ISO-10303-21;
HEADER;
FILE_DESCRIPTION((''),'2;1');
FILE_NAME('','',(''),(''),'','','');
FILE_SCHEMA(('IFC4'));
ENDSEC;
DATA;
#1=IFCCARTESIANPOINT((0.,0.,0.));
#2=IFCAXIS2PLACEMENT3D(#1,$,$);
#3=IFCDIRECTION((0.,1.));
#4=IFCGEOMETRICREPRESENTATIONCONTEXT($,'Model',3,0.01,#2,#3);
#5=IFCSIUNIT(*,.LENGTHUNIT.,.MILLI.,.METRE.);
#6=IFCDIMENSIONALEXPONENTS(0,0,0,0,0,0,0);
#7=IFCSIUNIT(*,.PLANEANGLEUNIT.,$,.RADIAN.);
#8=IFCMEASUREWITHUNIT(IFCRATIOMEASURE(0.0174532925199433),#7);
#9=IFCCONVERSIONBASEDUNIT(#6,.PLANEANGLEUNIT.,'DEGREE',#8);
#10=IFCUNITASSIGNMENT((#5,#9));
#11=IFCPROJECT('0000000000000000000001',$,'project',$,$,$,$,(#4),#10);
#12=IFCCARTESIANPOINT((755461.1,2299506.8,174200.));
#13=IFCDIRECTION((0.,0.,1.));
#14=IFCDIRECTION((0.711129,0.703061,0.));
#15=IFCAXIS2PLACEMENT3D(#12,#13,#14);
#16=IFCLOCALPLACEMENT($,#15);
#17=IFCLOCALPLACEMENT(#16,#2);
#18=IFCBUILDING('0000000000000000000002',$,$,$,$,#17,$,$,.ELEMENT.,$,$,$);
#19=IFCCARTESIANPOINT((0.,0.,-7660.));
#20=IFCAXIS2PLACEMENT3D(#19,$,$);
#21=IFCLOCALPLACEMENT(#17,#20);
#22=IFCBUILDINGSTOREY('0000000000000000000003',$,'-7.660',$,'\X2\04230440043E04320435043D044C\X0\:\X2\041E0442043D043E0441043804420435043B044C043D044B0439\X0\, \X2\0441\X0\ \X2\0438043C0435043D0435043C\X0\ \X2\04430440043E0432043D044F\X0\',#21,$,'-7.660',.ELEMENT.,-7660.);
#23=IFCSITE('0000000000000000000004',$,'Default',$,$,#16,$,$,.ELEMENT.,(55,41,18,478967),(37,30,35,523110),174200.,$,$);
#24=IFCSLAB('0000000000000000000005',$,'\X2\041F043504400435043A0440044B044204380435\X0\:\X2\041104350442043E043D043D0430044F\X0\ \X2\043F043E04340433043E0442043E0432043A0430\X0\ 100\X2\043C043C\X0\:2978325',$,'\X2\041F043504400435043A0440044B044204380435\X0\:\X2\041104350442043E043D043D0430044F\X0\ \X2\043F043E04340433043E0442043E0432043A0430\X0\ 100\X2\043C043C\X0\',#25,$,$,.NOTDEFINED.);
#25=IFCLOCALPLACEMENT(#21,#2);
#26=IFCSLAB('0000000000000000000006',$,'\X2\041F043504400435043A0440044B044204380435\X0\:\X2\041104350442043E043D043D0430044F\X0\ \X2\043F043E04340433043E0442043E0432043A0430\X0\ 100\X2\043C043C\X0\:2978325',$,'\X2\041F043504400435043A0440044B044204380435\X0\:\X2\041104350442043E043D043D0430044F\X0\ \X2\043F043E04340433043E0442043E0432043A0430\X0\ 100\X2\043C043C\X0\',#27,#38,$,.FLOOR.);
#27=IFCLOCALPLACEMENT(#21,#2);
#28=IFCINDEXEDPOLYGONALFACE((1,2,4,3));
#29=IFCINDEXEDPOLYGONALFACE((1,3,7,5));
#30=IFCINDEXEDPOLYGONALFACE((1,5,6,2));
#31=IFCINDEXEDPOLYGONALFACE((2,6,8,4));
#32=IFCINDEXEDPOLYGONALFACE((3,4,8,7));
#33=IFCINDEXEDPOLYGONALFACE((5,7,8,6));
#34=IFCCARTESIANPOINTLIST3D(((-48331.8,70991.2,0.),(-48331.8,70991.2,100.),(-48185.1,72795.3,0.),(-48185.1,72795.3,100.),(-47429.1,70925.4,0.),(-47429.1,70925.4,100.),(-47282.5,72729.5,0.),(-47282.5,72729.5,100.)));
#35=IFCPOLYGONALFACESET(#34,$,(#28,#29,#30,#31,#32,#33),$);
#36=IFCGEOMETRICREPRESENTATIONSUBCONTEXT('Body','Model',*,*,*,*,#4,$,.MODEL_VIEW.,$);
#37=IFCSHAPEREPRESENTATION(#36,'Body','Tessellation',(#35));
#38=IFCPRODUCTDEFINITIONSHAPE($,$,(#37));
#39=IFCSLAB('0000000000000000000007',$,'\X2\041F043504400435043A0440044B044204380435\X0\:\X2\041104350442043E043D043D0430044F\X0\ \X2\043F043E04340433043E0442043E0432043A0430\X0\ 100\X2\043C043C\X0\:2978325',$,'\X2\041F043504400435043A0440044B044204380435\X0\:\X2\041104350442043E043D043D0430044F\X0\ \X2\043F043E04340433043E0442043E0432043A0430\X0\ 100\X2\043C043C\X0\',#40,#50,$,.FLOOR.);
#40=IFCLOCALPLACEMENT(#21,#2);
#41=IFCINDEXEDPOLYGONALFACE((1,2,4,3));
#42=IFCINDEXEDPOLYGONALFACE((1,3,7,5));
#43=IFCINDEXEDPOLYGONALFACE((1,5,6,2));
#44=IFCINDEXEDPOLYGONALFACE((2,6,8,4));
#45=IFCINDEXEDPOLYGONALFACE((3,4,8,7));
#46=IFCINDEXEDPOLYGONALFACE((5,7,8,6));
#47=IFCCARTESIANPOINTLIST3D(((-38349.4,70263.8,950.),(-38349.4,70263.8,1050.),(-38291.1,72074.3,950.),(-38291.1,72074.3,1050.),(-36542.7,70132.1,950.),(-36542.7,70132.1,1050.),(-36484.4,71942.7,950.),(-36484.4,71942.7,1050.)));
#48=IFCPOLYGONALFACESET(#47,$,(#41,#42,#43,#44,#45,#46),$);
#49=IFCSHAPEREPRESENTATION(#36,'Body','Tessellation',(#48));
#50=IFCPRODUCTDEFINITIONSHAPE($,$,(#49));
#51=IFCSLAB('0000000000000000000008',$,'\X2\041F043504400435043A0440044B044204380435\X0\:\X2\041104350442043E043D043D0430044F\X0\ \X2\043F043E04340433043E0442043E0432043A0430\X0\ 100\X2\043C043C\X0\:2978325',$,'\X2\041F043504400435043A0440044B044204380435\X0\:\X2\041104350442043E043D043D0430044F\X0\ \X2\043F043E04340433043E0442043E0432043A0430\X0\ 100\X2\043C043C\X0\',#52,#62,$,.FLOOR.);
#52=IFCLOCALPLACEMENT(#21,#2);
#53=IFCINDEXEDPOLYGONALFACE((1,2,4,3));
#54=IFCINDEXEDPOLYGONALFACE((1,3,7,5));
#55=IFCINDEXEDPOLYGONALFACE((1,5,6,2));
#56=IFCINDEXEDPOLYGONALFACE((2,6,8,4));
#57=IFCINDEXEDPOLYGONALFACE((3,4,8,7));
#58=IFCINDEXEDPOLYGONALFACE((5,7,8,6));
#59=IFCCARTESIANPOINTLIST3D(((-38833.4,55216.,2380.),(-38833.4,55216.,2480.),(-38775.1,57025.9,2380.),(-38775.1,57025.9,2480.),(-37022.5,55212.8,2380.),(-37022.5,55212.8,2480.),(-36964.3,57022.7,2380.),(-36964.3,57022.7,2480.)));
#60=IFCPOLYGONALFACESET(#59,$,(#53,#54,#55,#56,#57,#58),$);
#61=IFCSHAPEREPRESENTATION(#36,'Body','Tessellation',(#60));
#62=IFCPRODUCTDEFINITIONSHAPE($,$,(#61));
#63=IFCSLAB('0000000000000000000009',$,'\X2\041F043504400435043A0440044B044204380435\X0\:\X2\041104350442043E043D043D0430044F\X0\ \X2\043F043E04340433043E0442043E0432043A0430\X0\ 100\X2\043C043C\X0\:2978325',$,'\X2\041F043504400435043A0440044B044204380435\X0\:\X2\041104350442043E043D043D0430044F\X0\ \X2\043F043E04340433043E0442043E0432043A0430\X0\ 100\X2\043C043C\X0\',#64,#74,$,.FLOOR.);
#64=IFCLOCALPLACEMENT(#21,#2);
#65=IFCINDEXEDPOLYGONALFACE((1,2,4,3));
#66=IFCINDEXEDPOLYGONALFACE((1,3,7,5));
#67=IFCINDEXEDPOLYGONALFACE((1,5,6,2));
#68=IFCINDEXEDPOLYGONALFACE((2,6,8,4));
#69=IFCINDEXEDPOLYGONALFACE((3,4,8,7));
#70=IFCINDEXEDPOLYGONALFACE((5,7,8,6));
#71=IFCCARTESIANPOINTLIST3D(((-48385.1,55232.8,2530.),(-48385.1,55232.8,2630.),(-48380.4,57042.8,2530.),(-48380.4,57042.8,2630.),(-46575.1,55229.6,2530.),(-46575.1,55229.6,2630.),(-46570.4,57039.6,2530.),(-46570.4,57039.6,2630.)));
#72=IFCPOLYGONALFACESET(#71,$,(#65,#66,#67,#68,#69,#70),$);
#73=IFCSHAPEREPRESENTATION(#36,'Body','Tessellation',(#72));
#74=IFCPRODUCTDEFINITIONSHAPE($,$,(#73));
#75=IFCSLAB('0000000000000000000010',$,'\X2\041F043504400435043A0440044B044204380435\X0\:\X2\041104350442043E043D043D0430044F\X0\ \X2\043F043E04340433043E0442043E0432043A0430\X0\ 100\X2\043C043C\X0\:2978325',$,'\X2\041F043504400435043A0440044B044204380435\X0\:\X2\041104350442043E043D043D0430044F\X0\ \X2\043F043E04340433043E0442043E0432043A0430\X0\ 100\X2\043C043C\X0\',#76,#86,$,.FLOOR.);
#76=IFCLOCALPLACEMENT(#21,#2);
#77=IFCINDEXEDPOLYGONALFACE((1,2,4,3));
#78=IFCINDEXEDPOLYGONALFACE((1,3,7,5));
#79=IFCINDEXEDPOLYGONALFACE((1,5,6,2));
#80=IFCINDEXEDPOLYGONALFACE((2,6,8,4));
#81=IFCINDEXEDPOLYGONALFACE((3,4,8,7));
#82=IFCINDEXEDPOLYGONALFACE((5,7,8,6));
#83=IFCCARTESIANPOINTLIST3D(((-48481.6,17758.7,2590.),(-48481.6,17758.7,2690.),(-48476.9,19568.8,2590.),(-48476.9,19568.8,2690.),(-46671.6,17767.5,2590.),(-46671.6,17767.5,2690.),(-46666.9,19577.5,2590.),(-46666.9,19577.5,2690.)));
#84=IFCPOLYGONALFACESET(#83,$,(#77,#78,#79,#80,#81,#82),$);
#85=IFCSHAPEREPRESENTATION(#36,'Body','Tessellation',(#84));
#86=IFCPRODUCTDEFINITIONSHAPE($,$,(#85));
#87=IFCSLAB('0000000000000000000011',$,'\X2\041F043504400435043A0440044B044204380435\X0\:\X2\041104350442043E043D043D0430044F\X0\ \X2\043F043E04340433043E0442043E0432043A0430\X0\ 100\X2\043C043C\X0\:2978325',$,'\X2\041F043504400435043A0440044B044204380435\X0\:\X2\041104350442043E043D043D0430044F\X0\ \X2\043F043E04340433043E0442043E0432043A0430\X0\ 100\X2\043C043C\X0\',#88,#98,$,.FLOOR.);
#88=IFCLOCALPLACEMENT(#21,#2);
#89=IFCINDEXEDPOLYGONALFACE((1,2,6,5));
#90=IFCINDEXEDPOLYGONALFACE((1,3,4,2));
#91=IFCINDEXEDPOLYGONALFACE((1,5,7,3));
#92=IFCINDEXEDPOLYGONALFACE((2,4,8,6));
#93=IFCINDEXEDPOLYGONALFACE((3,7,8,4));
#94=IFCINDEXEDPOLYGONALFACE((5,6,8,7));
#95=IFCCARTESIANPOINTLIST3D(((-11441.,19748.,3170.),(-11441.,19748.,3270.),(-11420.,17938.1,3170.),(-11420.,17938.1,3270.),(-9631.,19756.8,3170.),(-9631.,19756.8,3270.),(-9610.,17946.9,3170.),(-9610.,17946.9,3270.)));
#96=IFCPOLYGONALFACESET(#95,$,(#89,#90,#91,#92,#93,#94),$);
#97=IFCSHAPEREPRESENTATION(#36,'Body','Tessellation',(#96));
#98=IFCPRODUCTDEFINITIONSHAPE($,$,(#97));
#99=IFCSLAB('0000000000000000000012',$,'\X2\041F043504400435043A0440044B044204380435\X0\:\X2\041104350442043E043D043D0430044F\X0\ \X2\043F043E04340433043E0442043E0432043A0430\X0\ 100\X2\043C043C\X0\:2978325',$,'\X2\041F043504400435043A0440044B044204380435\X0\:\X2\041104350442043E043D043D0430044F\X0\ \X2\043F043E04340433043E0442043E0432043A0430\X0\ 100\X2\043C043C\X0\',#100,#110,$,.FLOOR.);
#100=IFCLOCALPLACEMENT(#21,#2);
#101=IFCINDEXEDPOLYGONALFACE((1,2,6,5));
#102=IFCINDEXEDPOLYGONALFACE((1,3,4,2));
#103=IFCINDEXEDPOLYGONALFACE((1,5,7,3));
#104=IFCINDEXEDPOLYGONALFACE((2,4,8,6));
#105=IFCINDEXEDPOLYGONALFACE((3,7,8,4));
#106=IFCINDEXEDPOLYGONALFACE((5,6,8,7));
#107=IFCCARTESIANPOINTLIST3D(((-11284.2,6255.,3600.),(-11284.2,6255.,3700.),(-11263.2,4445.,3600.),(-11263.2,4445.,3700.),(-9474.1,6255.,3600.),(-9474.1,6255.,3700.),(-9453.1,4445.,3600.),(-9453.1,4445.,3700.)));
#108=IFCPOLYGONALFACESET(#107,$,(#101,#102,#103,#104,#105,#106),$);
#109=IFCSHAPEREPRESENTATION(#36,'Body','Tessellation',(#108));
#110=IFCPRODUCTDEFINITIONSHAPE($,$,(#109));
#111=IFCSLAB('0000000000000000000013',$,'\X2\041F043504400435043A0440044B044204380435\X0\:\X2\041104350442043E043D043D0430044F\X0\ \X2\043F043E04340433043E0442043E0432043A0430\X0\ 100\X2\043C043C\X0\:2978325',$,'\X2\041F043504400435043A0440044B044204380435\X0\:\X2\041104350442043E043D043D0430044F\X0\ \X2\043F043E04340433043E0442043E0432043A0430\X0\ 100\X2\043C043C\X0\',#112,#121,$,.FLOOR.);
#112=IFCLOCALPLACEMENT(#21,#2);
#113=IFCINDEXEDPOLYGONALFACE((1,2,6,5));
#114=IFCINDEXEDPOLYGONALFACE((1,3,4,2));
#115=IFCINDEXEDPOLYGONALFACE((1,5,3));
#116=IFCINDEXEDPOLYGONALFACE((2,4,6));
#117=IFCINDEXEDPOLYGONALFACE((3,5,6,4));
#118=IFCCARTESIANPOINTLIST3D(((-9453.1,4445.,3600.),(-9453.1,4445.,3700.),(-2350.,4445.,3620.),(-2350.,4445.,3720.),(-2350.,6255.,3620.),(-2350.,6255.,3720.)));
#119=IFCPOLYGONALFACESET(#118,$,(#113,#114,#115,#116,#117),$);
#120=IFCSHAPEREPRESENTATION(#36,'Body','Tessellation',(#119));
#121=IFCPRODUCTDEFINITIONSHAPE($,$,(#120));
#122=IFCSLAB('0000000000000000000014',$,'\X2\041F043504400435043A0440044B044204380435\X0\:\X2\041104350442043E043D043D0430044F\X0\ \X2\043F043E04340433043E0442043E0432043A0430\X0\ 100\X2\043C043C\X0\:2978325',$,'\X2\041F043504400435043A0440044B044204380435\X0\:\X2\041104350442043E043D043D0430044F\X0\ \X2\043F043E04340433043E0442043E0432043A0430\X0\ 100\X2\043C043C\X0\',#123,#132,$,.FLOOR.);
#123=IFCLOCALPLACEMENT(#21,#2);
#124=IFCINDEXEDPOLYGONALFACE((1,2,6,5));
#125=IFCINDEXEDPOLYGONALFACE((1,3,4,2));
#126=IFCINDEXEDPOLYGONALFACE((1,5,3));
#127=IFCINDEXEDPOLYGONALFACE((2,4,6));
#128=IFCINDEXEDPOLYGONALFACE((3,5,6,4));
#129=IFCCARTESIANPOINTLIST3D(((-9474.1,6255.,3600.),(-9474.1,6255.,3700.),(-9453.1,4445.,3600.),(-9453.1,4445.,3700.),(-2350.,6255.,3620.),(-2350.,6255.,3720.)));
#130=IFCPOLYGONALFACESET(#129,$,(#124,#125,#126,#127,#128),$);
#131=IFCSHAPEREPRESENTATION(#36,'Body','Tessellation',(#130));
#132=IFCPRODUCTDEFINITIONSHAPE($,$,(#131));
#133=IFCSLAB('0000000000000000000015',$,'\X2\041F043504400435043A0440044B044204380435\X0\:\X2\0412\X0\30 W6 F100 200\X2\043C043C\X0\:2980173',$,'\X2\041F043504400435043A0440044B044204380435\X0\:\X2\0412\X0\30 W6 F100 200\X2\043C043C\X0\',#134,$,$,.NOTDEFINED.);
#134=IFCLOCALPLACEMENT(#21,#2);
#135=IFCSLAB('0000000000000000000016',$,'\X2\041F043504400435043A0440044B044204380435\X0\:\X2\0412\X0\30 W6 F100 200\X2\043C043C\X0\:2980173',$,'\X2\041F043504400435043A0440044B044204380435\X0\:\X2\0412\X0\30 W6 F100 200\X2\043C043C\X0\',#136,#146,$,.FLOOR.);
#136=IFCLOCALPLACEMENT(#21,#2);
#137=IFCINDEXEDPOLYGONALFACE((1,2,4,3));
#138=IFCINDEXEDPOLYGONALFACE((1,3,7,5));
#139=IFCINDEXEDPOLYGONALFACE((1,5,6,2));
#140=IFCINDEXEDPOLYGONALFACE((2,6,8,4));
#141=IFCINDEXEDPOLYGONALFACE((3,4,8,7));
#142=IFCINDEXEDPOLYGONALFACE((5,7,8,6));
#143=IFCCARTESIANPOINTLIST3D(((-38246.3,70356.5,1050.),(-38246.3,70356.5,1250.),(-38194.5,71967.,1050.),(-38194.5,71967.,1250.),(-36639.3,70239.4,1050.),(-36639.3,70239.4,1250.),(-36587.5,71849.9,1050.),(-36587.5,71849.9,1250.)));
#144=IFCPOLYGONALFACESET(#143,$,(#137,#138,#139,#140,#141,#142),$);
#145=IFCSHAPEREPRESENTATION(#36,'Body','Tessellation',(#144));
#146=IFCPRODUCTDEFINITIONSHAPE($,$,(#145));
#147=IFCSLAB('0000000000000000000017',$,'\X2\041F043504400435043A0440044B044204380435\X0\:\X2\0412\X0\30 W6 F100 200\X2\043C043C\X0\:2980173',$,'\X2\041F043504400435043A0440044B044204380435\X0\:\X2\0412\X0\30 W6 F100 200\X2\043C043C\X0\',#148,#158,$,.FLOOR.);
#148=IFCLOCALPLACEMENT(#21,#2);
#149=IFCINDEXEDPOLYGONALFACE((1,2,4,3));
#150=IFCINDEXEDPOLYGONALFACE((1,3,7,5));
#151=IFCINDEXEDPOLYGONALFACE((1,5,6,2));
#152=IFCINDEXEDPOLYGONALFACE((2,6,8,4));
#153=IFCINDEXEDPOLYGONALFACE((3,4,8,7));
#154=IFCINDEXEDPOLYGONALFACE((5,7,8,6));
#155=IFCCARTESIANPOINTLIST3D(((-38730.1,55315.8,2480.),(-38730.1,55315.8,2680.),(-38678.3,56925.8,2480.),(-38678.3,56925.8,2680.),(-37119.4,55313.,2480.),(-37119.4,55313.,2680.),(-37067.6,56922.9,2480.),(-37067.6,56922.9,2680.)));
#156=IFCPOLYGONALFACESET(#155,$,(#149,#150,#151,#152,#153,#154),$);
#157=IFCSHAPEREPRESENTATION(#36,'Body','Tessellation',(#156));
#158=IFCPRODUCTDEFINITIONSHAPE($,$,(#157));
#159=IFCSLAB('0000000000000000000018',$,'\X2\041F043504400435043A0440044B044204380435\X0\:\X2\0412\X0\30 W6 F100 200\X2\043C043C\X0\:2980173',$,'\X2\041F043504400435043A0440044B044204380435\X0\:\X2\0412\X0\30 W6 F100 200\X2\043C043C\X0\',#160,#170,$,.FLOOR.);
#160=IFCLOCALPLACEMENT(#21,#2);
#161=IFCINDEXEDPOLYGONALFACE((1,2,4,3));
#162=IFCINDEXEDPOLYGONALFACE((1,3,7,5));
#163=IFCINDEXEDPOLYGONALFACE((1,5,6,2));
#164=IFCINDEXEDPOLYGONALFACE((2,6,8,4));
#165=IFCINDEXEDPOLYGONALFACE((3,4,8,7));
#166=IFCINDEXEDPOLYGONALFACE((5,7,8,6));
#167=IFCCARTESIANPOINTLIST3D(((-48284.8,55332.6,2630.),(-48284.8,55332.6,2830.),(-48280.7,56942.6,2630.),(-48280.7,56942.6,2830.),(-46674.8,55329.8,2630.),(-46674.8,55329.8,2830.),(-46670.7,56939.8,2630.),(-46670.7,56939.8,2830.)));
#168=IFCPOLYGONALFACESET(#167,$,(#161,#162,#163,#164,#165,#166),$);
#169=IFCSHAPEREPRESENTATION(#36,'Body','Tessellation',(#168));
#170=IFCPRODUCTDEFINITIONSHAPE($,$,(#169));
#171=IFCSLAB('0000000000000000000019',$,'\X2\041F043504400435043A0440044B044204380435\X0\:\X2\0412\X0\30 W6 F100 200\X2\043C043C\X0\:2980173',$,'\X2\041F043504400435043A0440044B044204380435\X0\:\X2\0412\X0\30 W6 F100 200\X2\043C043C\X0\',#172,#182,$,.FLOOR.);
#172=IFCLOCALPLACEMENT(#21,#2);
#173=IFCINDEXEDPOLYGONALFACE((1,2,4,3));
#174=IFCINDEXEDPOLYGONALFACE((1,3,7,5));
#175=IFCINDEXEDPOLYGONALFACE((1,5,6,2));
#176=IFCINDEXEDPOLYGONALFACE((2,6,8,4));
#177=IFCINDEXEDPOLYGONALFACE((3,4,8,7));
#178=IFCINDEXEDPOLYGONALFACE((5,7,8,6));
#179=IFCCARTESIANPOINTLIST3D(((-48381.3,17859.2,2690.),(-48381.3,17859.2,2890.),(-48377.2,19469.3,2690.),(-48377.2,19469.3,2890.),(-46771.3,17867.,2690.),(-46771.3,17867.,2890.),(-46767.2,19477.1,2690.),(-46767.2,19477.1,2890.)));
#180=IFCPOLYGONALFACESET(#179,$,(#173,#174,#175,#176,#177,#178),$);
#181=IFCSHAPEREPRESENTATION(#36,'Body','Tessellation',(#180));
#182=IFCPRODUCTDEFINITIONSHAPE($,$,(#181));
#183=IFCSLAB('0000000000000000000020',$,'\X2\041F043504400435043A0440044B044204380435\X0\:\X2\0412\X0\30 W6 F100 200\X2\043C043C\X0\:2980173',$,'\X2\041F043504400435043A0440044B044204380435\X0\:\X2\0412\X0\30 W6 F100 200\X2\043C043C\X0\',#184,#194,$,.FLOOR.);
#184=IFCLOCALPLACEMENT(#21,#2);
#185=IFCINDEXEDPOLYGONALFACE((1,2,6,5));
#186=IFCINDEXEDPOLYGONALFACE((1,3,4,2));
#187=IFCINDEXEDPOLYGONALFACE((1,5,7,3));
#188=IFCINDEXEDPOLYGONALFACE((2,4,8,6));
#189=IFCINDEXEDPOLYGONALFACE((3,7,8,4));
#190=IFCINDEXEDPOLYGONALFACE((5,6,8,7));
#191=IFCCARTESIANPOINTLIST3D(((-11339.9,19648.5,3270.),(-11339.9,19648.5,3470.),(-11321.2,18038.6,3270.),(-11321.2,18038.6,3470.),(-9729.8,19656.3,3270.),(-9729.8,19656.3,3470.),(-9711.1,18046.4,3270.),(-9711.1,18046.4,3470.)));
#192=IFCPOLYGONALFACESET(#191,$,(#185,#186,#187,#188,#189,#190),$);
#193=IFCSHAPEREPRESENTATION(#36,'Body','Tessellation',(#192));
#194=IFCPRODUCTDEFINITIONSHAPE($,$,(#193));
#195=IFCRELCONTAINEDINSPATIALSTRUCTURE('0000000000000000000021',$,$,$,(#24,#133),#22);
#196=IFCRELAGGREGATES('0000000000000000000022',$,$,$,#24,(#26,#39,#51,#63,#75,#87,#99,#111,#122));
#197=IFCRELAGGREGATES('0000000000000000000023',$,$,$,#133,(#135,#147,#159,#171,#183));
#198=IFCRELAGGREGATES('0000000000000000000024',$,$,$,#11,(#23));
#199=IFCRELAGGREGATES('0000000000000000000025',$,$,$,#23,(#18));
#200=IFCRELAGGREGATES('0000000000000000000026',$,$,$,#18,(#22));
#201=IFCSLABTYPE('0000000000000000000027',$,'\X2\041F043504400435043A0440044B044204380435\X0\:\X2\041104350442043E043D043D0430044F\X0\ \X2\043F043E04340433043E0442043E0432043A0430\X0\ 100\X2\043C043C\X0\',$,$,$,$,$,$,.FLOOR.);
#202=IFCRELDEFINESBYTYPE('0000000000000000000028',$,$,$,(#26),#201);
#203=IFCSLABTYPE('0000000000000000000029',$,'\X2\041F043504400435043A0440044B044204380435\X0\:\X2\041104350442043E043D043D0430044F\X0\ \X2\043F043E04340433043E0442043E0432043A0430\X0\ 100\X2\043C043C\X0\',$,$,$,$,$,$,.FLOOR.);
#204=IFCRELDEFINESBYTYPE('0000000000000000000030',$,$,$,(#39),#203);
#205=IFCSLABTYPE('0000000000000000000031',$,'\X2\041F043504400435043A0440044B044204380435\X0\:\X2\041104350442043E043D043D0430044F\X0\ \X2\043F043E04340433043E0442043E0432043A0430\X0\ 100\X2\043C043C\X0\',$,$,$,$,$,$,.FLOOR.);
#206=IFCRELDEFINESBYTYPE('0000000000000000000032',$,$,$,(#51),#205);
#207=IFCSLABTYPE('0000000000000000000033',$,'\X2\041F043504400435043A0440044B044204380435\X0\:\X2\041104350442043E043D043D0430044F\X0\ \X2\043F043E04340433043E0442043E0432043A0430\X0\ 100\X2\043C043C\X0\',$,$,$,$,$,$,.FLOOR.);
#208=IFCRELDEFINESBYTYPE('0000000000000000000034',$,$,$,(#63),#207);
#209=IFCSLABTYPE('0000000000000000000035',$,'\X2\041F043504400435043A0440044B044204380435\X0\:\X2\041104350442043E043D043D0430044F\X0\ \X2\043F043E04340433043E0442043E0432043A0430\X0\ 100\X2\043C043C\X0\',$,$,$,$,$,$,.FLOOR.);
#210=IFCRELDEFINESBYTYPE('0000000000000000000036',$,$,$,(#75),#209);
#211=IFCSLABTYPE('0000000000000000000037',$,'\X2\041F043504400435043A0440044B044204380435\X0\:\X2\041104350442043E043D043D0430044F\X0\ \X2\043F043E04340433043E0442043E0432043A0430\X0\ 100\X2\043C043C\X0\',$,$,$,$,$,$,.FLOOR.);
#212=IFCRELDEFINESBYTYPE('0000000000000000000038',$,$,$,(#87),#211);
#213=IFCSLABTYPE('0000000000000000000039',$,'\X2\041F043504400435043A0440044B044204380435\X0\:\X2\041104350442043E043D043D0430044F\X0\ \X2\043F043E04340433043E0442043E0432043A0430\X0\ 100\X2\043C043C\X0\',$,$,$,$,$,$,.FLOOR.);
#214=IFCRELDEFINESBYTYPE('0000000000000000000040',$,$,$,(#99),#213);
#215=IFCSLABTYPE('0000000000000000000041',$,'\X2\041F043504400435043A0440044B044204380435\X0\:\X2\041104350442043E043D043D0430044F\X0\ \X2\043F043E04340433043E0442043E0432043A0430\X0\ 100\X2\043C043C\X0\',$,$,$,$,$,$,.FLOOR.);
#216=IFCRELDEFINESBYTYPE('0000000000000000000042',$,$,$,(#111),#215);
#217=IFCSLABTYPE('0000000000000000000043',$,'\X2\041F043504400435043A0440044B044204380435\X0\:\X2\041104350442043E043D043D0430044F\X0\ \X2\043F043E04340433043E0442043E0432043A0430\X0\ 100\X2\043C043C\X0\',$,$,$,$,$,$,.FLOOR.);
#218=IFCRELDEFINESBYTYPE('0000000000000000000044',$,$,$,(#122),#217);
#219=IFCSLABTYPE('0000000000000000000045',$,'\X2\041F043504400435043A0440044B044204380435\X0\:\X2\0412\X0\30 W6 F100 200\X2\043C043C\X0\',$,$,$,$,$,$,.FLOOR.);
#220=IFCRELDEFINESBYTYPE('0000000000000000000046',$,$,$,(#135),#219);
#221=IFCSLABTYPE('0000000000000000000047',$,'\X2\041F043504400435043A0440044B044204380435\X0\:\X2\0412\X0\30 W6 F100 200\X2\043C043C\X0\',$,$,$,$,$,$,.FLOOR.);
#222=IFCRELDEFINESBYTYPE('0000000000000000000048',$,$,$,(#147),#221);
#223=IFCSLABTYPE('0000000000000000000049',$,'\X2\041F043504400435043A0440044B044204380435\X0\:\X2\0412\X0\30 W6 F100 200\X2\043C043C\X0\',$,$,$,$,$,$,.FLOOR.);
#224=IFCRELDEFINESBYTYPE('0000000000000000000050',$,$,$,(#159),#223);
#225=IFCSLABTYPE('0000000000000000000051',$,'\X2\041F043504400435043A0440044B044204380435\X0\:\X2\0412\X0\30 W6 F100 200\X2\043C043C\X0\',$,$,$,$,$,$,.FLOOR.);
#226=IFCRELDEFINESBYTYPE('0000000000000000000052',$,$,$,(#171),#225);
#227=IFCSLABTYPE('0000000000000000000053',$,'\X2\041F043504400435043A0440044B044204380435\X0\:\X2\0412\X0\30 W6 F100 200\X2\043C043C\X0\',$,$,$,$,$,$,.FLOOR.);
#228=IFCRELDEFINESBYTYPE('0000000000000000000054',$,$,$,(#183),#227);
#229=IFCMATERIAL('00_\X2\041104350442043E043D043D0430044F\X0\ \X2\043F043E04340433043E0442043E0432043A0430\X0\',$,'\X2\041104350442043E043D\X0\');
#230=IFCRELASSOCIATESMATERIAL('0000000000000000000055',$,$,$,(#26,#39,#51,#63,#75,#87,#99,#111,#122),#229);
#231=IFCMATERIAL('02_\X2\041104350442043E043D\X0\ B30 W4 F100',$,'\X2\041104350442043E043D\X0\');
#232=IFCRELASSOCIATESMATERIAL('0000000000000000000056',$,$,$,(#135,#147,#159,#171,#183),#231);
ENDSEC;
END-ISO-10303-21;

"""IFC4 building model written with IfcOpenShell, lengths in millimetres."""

from ifc_helpers import new_model, entity, si_unit, converted_unit, direction, frame, origin, place, context, subcontext, project, spatial, indexed_curve, outline, extrude, material, type_object, element, aggregate, save


model = new_model("IFC4")

# Units and contexts
model_context = context("Model", 3, precision=0.01, world=origin(), true_north=direction((0.0, 1.0)))
body_context = subcontext(model_context, "Body", "Model", "MODEL_VIEW")
ifc_project = project(units=[si_unit("LENGTHUNIT", "METRE", prefix="MILLI"), converted_unit("PLANEANGLEUNIT", "DEGREE", entity("IfcRatioMeasure", 0.0174532925199433), si_unit("PLANEANGLEUNIT", "RADIAN"), dimensions=[0, 0, 0, 0, 0, 0, 0])], contexts=[model_context])

# Site, building, storey
site_placement = place(None, frame((755461.1, 2299506.8, 174200.0), z_axis=(0.0, 0.0, 1.0), x_axis=(0.711129, 0.703061, 0.0)))
site = spatial("IfcSite", under=ifc_project, at=site_placement, Name="Default", CompositionType="ELEMENT", RefLatitude=(55, 41, 18, 478967), RefLongitude=(37, 30, 35, 523110), RefElevation=174200.0)
building_placement = place(site_placement, origin())
building = spatial("IfcBuilding", under=site, at=building_placement, CompositionType="ELEMENT")
storey_placement = place(building_placement, frame((0.0, 0.0, -7660.0)))
storey = spatial("IfcBuildingStorey", under=building, at=storey_placement, Name="-7.660", ObjectType="Уровень:Относительный, с именем уровня", LongName="-7.660", CompositionType="ELEMENT", Elevation=-7660.0)

# Slabs
slab_1_placement = place(storey_placement, frame((-48481.6, 4445.0, 0.0)))
slab_1 = element("IfcSlab", 1, at=slab_1_placement, inside=storey, Name="Перекрытие:Бетонная подготовка 100мм:2978325", ObjectType="Перекрытие:Бетонная подготовка 100мм", PredefinedType="NOTDEFINED")
ifc_material_1 = material(Name="00_Бетонная подготовка", Category="Бетон")
slab_type_1 = type_object("IfcSlabType", Name="Перекрытие:Бетонная подготовка 100мм", PredefinedType="FLOOR")
slab_2_placement = place(slab_1_placement, origin())
slab_2 = element("IfcSlab", 2, at=slab_2_placement, type_object=slab_type_1, material=ifc_material_1, Name="Перекрытие:Бетонная подготовка 100мм:2978325", ObjectType="Перекрытие:Бетонная подготовка 100мм", PredefinedType="FLOOR", context=body_context, shape_type="SweptSolid", body=[
    extrude(outline(indexed_curve([(-524.7, -869.2), (378.0, -934.9), (524.7, 869.2), (-378.0, 934.9), (-524.7, -869.2)], self_intersect=False)), frame((674.5, 67415.3, 100.0)), (0.0, 0.0, -1.0), 100.0),
])
slab_type_2 = type_object("IfcSlabType", Name="Перекрытие:Бетонная подготовка 100мм", PredefinedType="FLOOR")
slab_3_placement = place(slab_1_placement, origin())
slab_3 = element("IfcSlab", 3, at=slab_3_placement, type_object=slab_type_2, material=ifc_material_1, Name="Перекрытие:Бетонная подготовка 100мм:2978325", ObjectType="Перекрытие:Бетонная подготовка 100мм", PredefinedType="FLOOR", context=body_context, shape_type="SweptSolid", body=[
    extrude(outline(indexed_curve([(-932.5, -839.5), (874.2, -971.1), (932.5, 839.5), (-874.2, 971.1), (-932.5, -839.5)], self_intersect=False)), frame((11064.7, 66658.2, 1050.0)), (0.0, 0.0, -1.0), 100.0),
])
slab_type_3 = type_object("IfcSlabType", Name="Перекрытие:Бетонная подготовка 100мм", PredefinedType="FLOOR")
slab_4_placement = place(slab_1_placement, origin())
slab_4 = element("IfcSlab", 4, at=slab_4_placement, type_object=slab_type_3, material=ifc_material_1, Name="Перекрытие:Бетонная подготовка 100мм:2978325", ObjectType="Перекрытие:Бетонная подготовка 100мм", PredefinedType="FLOOR", context=body_context, shape_type="SweptSolid", body=[
    extrude(outline(indexed_curve([(-876.3, 906.5), (-934.5, -903.4), (876.3, -906.5), (934.5, 903.4), (-876.3, 906.5)], self_intersect=False)), frame((10582.8, 51674.4, 2480.0)), (0.0, 0.0, -1.0), 100.0),
])
slab_type_4 = type_object("IfcSlabType", Name="Перекрытие:Бетонная подготовка 100мм", PredefinedType="FLOOR")
slab_5_placement = place(slab_1_placement, origin())
slab_5 = element("IfcSlab", 5, at=slab_5_placement, type_object=slab_type_4, material=ifc_material_1, Name="Перекрытие:Бетонная подготовка 100мм:2978325", ObjectType="Перекрытие:Бетонная подготовка 100мм", PredefinedType="FLOOR", context=body_context, shape_type="SweptSolid", body=[
    extrude(outline(indexed_curve([(-902.7, 906.6), (-907.3, -903.4), (902.7, -906.6), (907.3, 903.4), (-902.7, 906.6)], self_intersect=False)), frame((1003.8, 51691.2, 2630.0)), (0.0, 0.0, -1.0), 100.0),
])
slab_type_5 = type_object("IfcSlabType", Name="Перекрытие:Бетонная подготовка 100мм", PredefinedType="FLOOR")
slab_6_placement = place(slab_1_placement, origin())
slab_6 = element("IfcSlab", 6, at=slab_6_placement, type_object=slab_type_5, material=ifc_material_1, Name="Перекрытие:Бетонная подготовка 100мм:2978325", ObjectType="Перекрытие:Бетонная подготовка 100мм", PredefinedType="FLOOR", context=body_context, shape_type="SweptSolid", body=[
    extrude(outline(indexed_curve([(-907.3, -909.4), (902.7, -900.6), (907.3, 909.4), (-902.7, 900.6), (-907.3, -909.4)], self_intersect=False)), frame((907.3, 14223.1, 2690.0)), (0.0, 0.0, -1.0), 100.0),
])
slab_type_6 = type_object("IfcSlabType", Name="Перекрытие:Бетонная подготовка 100мм", PredefinedType="FLOOR")
slab_7_placement = place(slab_1_placement, origin())
slab_7 = element("IfcSlab", 7, at=slab_7_placement, type_object=slab_type_6, material=ifc_material_1, Name="Перекрытие:Бетонная подготовка 100мм:2978325", ObjectType="Перекрытие:Бетонная подготовка 100мм", PredefinedType="FLOOR", context=body_context, shape_type="SweptSolid", body=[
    extrude(outline(indexed_curve([(-894.5, -909.3), (915.5, -900.6), (894.5, 909.3), (-915.5, 900.6), (-894.5, -909.3)], self_intersect=False)), frame((37956.1, 14402.4, 3270.0)), (0.0, 0.0, -1.0), 100.0),
])
slab_type_7 = type_object("IfcSlabType", Name="Перекрытие:Бетонная подготовка 100мм", PredefinedType="FLOOR")
slab_8_placement = place(slab_1_placement, origin())
slab_8 = element("IfcSlab", 8, at=slab_8_placement, type_object=slab_type_7, material=ifc_material_1, Name="Перекрытие:Бетонная подготовка 100мм:2978325", ObjectType="Перекрытие:Бетонная подготовка 100мм", PredefinedType="FLOOR", context=body_context, shape_type="SweptSolid", body=[
    extrude(outline(indexed_curve([(-894.5, -905.0), (915.6, -905.0), (894.5, 905.0), (-915.6, 905.0), (-894.5, -905.0)], self_intersect=False)), frame((38112.9, 905.0, 3700.0)), (0.0, 0.0, -1.0), 100.0),
])
slab_type_8 = type_object("IfcSlabType", Name="Перекрытие:Бетонная подготовка 100мм", PredefinedType="FLOOR")
slab_9_placement = place(slab_1_placement, origin())
slab_9 = element("IfcSlab", 9, at=slab_9_placement, type_object=slab_type_8, material=ifc_material_1, Name="Перекрытие:Бетонная подготовка 100мм:2978325", ObjectType="Перекрытие:Бетонная подготовка 100мм", PredefinedType="FLOOR", context=body_context, shape_type="SweptSolid", body=[
    extrude(outline(indexed_curve([(3551.5, -905.0), (3551.5, 905.0), (-3551.5, -905.0), (3551.5, -905.0)], self_intersect=False)), frame((42580.1, 905.0, 3710.0), z_axis=(-0.002816, 0.0, 0.999996), x_axis=(0.999996, 0.0, 0.002816)), (-0.002816, 0.0, -0.999996), 100.0),
])
slab_type_9 = type_object("IfcSlabType", Name="Перекрытие:Бетонная подготовка 100мм", PredefinedType="FLOOR")
slab_10_placement = place(slab_1_placement, origin())
slab_10 = element("IfcSlab", 10, at=slab_10_placement, type_object=slab_type_9, material=ifc_material_1, Name="Перекрытие:Бетонная подготовка 100мм:2978325", ObjectType="Перекрытие:Бетонная подготовка 100мм", PredefinedType="FLOOR", context=body_context, shape_type="SweptSolid", body=[
    extrude(outline(indexed_curve([(3562.1, 905.0), (-3562.1, 905.0), (-3541.0, -905.0), (3562.1, 905.0)], self_intersect=False)), frame((42569.5, 905.0, 3710.0), z_axis=(-0.002807, -0.000033, 0.999996), x_axis=(0.999996, 0.0, 0.002807)), (-0.002807, -0.000033, -0.999996), 100.0),
])
aggregate(slab_1, [slab_2, slab_3, slab_4, slab_5, slab_6, slab_7, slab_8, slab_9, slab_10])
slab_11_placement = place(storey_placement, frame((-48381.3, 4545.0, 100.0)))
slab_11 = element("IfcSlab", 11, at=slab_11_placement, inside=storey, Name="Перекрытие:В30 W6 F100 200мм:2980173", ObjectType="Перекрытие:В30 W6 F100 200мм", PredefinedType="NOTDEFINED")
ifc_material_2 = material(Name="02_Бетон B30 W4 F100", Category="Бетон")
slab_type_10 = type_object("IfcSlabType", Name="Перекрытие:В30 W6 F100 200мм", PredefinedType="FLOOR")
slab_12_placement = place(slab_11_placement, origin())
slab_12 = element("IfcSlab", 12, at=slab_12_placement, type_object=slab_type_10, material=ifc_material_2, Name="Перекрытие:В30 W6 F100 200мм:2980173", ObjectType="Перекрытие:В30 W6 F100 200мм", PredefinedType="FLOOR", context=body_context, shape_type="SweptSolid", body=[
    extrude(outline(indexed_curve([(-829.4, -746.7), (777.6, -863.8), (829.4, 746.7), (-777.6, 863.8), (-829.4, -746.7)], self_intersect=False)), frame((10964.4, 66558.2, 1150.0)), (0.0, 0.0, -1.0), 200.0),
])
slab_type_11 = type_object("IfcSlabType", Name="Перекрытие:В30 W6 F100 200мм", PredefinedType="FLOOR")
slab_13_placement = place(slab_11_placement, origin())
slab_13 = element("IfcSlab", 13, at=slab_13_placement, type_object=slab_type_11, material=ifc_material_2, Name="Перекрытие:В30 W6 F100 200мм:2980173", ObjectType="Перекрытие:В30 W6 F100 200мм", PredefinedType="FLOOR", context=body_context, shape_type="SweptSolid", body=[
    extrude(outline(indexed_curve([(-779.5, 806.4), (-831.3, -803.5), (779.5, -806.4), (831.3, 803.5), (-779.5, 806.4)], self_intersect=False)), frame((10482.5, 51574.4, 2580.0)), (0.0, 0.0, -1.0), 200.0),
])
slab_type_12 = type_object("IfcSlabType", Name="Перекрытие:В30 W6 F100 200мм", PredefinedType="FLOOR")
slab_14_placement = place(slab_11_placement, origin())
slab_14 = element("IfcSlab", 14, at=slab_14_placement, type_object=slab_type_12, material=ifc_material_2, Name="Перекрытие:В30 W6 F100 200мм:2980173", ObjectType="Перекрытие:В30 W6 F100 200мм", PredefinedType="FLOOR", context=body_context, shape_type="SweptSolid", body=[
    extrude(outline(indexed_curve([(-802.9, 806.4), (-807.1, -803.6), (802.9, -806.4), (807.1, 803.6), (-802.9, 806.4)], self_intersect=False)), frame((903.6, 51591.2, 2730.0)), (0.0, 0.0, -1.0), 200.0),
])
slab_type_13 = type_object("IfcSlabType", Name="Перекрытие:В30 W6 F100 200мм", PredefinedType="FLOOR")
slab_15_placement = place(slab_11_placement, origin())
slab_15 = element("IfcSlab", 15, at=slab_15_placement, type_object=slab_type_13, material=ifc_material_2, Name="Перекрытие:В30 W6 F100 200мм:2980173", ObjectType="Перекрытие:В30 W6 F100 200мм", PredefinedType="FLOOR", context=body_context, shape_type="SweptSolid", body=[
    extrude(outline(indexed_curve([(-807.1, -808.9), (802.9, -801.1), (807.1, 808.9), (-802.9, 801.1), (-807.1, -808.9)], self_intersect=False)), frame((807.1, 14123.1, 2790.0)), (0.0, 0.0, -1.0), 200.0),
])
slab_type_14 = type_object("IfcSlabType", Name="Перекрытие:В30 W6 F100 200мм", PredefinedType="FLOOR")
slab_16_placement = place(slab_11_placement, origin())
slab_16 = element("IfcSlab", 16, at=slab_16_placement, type_object=slab_type_14, material=ifc_material_2, Name="Перекрытие:В30 W6 F100 200мм:2980173", ObjectType="Перекрытие:В30 W6 F100 200мм", PredefinedType="FLOOR", context=body_context, shape_type="SweptSolid", body=[
    extrude(outline(indexed_curve([(-795.7, -808.9), (814.4, -801.1), (795.7, 808.9), (-814.4, 801.1), (-795.7, -808.9)], self_intersect=False)), frame((37855.8, 14302.4, 3370.0)), (0.0, 0.0, -1.0), 200.0),
])
aggregate(slab_11, [slab_12, slab_13, slab_14, slab_15, slab_16])

save(model, "model.ifc")
